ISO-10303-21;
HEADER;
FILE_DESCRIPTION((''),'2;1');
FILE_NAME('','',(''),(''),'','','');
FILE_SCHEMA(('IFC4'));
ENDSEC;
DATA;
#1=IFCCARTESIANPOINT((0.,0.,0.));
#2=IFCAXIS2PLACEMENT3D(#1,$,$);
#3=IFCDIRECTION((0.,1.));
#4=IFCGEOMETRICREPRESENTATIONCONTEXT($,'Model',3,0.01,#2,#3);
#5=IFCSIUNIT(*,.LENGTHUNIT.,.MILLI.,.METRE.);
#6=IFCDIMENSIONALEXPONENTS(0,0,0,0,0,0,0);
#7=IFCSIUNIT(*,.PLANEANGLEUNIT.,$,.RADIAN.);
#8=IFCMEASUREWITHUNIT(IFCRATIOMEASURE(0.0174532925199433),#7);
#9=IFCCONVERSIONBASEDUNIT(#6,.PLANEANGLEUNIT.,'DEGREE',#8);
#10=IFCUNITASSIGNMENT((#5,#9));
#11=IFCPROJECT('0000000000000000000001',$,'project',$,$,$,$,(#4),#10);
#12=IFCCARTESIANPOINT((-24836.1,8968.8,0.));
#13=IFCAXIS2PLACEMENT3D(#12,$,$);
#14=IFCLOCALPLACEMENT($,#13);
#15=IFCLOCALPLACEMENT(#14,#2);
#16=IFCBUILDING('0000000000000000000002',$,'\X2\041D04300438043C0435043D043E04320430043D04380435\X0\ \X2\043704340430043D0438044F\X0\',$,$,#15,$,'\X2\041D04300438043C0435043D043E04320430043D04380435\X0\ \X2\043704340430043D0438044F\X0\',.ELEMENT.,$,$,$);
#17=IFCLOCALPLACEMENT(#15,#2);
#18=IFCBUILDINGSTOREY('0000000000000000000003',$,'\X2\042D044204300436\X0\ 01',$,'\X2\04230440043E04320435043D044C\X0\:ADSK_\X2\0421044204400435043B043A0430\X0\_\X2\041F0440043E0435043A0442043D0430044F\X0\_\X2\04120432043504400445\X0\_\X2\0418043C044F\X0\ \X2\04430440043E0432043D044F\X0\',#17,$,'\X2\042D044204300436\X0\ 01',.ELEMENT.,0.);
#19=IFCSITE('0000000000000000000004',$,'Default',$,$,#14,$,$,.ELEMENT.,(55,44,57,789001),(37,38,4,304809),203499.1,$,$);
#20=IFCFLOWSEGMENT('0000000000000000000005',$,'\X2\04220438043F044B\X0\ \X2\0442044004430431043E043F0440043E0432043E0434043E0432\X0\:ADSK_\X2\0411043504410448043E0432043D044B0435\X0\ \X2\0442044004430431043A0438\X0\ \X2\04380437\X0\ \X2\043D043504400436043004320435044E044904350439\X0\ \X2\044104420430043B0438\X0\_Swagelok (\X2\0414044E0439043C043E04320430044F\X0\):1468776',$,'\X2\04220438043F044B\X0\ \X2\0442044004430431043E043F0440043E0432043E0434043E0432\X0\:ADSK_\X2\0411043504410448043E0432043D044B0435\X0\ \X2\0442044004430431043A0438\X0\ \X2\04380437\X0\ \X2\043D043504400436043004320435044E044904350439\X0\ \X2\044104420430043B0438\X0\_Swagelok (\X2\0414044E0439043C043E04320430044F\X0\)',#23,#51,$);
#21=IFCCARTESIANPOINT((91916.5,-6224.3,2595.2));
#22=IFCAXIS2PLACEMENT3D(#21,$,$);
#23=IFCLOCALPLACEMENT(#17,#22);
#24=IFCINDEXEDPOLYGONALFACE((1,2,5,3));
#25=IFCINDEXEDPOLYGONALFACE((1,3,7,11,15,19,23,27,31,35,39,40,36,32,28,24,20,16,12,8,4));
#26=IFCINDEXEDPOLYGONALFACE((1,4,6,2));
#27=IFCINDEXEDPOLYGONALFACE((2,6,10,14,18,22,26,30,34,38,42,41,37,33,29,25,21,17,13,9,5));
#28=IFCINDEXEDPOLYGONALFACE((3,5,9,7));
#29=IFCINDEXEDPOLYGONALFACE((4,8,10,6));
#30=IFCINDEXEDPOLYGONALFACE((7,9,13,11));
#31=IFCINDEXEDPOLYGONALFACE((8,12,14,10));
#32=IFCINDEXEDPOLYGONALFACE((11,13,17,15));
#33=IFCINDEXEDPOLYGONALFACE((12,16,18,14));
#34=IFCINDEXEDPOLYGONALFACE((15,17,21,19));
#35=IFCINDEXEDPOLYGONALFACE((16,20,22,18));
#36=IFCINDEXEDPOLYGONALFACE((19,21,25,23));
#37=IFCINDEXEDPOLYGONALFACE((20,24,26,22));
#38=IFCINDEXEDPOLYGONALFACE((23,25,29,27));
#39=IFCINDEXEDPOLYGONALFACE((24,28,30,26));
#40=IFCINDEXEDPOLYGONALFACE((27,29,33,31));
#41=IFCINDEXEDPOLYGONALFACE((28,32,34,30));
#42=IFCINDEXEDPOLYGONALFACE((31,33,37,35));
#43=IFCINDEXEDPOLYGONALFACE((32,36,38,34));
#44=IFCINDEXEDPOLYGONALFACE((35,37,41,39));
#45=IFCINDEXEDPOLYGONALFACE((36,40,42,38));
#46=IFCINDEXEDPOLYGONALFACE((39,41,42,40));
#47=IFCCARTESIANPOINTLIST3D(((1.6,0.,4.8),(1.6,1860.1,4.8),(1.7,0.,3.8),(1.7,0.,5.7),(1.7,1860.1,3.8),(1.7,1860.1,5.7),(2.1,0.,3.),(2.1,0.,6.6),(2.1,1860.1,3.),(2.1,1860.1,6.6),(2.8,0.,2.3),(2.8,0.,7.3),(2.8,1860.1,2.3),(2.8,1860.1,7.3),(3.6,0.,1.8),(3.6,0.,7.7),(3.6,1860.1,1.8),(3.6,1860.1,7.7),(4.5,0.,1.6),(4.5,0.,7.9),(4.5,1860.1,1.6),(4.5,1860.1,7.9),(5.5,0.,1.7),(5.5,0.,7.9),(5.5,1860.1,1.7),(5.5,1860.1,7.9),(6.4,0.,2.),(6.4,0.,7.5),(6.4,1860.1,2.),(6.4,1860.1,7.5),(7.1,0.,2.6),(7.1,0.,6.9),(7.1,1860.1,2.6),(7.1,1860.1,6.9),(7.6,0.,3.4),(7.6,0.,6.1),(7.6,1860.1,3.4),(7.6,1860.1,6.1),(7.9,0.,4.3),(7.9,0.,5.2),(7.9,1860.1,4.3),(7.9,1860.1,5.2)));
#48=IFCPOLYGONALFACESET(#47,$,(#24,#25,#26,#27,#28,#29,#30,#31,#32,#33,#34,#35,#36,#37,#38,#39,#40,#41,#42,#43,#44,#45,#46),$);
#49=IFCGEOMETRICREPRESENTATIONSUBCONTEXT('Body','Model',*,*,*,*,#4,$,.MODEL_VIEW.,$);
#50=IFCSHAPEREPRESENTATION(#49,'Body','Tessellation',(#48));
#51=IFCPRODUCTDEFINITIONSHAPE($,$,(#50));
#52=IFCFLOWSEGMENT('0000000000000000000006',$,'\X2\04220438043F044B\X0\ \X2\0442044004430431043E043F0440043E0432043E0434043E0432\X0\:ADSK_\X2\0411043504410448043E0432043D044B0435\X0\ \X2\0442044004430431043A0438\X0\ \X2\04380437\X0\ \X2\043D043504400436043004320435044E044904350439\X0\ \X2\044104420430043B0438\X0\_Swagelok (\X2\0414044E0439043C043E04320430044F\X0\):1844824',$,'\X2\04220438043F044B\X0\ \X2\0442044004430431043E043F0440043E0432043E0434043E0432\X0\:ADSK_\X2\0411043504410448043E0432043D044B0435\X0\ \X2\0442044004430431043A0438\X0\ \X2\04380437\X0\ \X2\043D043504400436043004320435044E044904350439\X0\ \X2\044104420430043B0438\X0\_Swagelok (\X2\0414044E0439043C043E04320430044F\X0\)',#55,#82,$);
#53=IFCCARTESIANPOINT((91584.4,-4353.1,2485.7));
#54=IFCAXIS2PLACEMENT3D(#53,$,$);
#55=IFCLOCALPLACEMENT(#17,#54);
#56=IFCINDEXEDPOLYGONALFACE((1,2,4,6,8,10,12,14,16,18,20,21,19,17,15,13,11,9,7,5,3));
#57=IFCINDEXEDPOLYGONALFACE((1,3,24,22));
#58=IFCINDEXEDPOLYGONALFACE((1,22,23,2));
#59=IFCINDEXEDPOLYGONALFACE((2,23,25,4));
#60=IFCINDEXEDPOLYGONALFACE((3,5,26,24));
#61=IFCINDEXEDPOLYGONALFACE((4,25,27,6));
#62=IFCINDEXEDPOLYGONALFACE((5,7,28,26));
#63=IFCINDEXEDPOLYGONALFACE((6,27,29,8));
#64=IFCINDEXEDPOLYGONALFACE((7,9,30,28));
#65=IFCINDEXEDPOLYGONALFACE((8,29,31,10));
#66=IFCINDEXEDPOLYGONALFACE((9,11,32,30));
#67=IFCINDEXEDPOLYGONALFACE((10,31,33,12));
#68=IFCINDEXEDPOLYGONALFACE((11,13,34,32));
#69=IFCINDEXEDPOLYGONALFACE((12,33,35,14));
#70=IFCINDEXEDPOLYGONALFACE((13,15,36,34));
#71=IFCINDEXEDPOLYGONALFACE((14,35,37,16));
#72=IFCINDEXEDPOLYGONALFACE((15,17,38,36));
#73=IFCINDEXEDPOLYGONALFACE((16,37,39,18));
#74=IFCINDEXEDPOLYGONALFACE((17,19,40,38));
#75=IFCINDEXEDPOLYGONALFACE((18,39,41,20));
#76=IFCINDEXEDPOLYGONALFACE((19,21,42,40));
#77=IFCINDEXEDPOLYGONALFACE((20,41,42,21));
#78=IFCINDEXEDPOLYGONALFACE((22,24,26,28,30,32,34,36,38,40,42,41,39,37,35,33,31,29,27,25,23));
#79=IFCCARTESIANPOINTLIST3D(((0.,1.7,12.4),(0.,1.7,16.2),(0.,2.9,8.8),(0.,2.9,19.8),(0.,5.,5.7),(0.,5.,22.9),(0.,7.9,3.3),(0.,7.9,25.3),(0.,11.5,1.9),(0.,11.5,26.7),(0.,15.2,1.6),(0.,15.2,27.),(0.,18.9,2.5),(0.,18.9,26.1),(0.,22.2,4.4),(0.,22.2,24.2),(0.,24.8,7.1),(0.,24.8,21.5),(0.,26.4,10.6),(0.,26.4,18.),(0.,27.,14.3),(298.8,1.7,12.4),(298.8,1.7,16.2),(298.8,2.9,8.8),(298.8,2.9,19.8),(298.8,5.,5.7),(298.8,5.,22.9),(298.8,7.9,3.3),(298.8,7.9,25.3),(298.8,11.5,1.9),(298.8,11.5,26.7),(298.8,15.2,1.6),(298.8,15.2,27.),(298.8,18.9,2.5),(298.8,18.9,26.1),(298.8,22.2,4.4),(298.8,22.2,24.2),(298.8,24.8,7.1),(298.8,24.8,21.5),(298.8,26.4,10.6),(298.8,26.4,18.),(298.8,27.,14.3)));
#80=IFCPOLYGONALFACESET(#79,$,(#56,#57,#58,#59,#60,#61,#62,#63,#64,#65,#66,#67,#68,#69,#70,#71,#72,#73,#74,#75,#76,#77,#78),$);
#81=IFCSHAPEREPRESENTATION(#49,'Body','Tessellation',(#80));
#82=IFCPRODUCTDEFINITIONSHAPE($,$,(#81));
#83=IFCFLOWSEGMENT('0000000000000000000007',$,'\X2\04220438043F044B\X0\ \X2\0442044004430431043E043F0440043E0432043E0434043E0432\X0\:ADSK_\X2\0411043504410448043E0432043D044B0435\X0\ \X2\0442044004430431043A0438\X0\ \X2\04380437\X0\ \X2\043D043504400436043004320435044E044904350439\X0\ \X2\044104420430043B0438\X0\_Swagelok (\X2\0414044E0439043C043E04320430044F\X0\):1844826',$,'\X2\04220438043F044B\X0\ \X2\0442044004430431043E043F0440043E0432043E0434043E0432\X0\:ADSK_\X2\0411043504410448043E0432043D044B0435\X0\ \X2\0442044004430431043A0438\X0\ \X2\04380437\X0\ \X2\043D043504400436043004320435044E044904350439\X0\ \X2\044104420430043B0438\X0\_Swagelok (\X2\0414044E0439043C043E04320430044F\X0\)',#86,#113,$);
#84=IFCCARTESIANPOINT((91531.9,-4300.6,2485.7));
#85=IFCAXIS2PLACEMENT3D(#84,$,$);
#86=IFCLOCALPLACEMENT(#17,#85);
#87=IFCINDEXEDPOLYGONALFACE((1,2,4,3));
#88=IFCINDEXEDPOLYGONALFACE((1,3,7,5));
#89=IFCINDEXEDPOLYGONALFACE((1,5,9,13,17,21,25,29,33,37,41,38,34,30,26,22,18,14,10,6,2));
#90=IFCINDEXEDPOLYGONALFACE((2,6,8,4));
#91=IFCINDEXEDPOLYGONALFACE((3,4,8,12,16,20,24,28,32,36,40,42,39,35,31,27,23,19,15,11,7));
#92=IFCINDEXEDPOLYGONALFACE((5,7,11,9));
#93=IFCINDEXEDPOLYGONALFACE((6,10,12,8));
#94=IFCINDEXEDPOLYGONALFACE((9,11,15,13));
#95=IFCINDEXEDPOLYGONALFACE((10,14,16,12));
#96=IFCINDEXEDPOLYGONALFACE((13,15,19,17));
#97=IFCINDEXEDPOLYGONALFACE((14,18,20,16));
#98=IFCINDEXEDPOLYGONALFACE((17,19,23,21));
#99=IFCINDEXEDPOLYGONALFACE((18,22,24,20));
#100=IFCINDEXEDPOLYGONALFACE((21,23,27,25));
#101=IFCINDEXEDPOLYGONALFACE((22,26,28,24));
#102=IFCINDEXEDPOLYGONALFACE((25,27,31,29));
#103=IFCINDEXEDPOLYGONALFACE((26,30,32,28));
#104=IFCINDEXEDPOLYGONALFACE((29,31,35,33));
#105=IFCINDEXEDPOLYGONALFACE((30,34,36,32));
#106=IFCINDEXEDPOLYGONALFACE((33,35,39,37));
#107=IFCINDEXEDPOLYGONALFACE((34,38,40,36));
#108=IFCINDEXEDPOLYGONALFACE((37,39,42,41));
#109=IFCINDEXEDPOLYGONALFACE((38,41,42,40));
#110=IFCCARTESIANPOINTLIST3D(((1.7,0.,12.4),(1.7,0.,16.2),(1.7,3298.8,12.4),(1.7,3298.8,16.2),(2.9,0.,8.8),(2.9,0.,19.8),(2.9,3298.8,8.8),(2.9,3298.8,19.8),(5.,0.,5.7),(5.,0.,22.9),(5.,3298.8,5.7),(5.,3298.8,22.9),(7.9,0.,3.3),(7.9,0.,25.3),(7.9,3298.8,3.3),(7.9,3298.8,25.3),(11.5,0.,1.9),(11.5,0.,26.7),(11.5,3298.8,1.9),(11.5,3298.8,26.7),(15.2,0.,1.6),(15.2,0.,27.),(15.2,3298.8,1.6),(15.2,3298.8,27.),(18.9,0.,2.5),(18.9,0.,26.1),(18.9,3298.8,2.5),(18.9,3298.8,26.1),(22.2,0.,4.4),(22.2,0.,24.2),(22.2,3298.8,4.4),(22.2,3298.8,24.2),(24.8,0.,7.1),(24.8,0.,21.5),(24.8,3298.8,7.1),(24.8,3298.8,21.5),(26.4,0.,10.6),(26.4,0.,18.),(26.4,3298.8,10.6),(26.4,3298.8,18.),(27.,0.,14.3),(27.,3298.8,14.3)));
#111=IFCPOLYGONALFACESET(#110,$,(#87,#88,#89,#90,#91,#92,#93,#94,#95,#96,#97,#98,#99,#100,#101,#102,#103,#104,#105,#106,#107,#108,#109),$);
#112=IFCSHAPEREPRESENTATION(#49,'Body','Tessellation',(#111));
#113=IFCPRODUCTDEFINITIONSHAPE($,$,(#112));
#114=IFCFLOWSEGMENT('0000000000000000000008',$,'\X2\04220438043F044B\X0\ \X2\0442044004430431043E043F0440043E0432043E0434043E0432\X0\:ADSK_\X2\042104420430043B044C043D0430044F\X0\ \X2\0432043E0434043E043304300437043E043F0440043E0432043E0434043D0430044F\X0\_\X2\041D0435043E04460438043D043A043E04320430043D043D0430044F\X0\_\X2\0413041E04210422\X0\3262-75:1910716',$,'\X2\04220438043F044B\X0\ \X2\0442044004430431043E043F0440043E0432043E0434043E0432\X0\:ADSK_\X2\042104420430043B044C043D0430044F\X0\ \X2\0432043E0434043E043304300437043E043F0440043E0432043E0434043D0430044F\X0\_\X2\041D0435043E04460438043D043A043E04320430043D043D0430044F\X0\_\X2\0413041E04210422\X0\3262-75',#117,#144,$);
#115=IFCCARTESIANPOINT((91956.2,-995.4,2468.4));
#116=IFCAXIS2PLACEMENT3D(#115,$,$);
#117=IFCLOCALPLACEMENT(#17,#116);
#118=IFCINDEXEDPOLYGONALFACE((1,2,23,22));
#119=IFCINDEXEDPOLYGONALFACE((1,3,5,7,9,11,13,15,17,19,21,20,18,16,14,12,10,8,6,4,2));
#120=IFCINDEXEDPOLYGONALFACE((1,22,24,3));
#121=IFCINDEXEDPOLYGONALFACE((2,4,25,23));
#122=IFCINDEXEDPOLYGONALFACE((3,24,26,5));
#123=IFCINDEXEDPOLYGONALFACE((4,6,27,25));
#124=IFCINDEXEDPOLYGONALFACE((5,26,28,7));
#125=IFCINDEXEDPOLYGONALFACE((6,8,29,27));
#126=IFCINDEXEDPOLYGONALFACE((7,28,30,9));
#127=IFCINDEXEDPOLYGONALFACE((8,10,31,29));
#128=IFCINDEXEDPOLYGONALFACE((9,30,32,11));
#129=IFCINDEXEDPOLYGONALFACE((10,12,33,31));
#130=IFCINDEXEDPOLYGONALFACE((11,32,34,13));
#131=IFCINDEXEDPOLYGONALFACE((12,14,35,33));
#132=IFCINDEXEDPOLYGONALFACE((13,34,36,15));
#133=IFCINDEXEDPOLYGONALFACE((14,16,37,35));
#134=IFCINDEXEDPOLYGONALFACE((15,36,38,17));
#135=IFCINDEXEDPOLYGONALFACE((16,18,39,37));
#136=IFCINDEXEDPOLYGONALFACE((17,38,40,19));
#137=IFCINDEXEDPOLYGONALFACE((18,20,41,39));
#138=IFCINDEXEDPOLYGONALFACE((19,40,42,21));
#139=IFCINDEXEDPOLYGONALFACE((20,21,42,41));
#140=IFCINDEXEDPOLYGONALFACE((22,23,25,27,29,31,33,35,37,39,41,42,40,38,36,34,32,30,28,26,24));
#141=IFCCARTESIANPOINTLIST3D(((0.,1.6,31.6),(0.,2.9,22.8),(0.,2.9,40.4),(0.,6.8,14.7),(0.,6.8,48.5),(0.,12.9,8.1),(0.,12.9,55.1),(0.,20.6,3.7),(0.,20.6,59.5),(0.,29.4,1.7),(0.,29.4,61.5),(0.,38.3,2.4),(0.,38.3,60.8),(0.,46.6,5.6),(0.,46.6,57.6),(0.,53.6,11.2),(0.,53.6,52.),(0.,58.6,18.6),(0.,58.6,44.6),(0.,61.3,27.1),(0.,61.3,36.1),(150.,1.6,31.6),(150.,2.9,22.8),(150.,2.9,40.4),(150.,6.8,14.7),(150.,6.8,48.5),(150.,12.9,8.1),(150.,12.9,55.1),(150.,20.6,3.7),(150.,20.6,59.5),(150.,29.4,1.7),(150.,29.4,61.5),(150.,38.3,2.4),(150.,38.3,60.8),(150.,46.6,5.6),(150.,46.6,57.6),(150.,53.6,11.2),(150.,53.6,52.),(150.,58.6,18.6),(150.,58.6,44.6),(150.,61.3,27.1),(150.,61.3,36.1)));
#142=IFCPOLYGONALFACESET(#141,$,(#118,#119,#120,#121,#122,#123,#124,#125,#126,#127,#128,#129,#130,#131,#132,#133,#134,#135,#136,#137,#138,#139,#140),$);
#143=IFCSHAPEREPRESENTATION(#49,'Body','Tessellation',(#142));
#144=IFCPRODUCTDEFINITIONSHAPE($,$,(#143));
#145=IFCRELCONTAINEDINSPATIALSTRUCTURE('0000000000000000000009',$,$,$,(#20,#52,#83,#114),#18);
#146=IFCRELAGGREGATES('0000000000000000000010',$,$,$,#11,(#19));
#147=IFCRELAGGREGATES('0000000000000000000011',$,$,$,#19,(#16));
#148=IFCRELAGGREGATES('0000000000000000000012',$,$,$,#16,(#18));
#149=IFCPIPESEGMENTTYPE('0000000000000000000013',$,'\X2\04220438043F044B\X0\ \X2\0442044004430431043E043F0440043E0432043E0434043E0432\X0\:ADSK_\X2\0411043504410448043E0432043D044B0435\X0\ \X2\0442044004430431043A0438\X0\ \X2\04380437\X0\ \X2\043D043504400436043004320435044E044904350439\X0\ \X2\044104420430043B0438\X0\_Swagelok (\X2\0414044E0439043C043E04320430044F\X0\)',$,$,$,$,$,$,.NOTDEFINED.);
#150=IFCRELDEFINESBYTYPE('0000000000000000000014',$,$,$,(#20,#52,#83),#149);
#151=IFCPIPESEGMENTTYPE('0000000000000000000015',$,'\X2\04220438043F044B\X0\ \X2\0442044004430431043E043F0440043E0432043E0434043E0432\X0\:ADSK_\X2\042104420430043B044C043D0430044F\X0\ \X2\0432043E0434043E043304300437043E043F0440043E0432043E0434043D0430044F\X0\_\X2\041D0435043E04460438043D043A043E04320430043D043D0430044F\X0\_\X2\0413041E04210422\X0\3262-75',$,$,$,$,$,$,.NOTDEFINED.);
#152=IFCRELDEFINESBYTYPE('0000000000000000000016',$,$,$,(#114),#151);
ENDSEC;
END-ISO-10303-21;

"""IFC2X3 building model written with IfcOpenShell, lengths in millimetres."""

from ifc_helpers import new_model, entity, si_unit, converted_unit, direction, frame, origin, origin_2d_with_axis, place, context, subcontext, project, spatial, circle, extrude, type_object, element, save


model = new_model("IFC2X3")

# Units and contexts
model_context = context("Model", 3, precision=0.01, world=origin(), true_north=direction((0.0, 1.0)))
body_context = subcontext(model_context, "Body", "Model", "MODEL_VIEW")
ifc_project = project(units=[si_unit("LENGTHUNIT", "METRE", prefix="MILLI"), converted_unit("PLANEANGLEUNIT", "DEGREE", entity("IfcRatioMeasure", 0.0174532925199433), si_unit("PLANEANGLEUNIT", "RADIAN"), dimensions=[0, 0, 0, 0, 0, 0, 0])], contexts=[model_context])

# Site, building, storey
site_placement = place(None, frame((-24836.1, 8968.8, 0.0)))
site = spatial("IfcSite", under=ifc_project, at=site_placement, Name="Default", CompositionType="ELEMENT", RefLatitude=(55, 44, 57, 789001), RefLongitude=(37, 38, 4, 304809), RefElevation=203499.1)
building_placement = place(site_placement, origin())
building = spatial("IfcBuilding", under=site, at=building_placement, Name="Наименование здания", LongName="Наименование здания", CompositionType="ELEMENT")
storey_placement = place(building_placement, origin())
storey = spatial("IfcBuildingStorey", under=building, at=storey_placement, Name="Этаж 01", ObjectType="Уровень:ADSK_Стрелка_Проектная_Вверх_Имя уровня", LongName="Этаж 01", CompositionType="ELEMENT", Elevation=0.0)

# Flow segments
pipe_segment_type_1 = type_object("IfcPipeSegmentType", Name="Типы трубопроводов:ADSK_Бесшовные трубки из нержавеющей стали_Swagelok (Дюймовая)", PredefinedType="NOTDEFINED")
flow_segment_1_placement = place(storey_placement, frame((91916.5, -6224.3, 2595.2)))
element("IfcFlowSegment", 1, at=flow_segment_1_placement, inside=storey, type_object=pipe_segment_type_1, Name="Типы трубопроводов:ADSK_Бесшовные трубки из нержавеющей стали_Swagelok (Дюймовая):1468776", ObjectType="Типы трубопроводов:ADSK_Бесшовные трубки из нержавеющей стали_Swagelok (Дюймовая)", context=body_context, shape_type="SweptSolid", body=[
    extrude(circle(Radius=3.2, at=origin_2d_with_axis()), frame((4.8, 0.0, 4.8), z_axis=(0.0, 1.0, 0.0), x_axis=(-1.0, 0.0, 0.0)), (0.0, 0.0, 1.0), 1860.1),
])
flow_segment_2_placement = place(storey_placement, frame((91584.4, -4353.1, 2485.7)))
element("IfcFlowSegment", 2, at=flow_segment_2_placement, inside=storey, type_object=pipe_segment_type_1, Name="Типы трубопроводов:ADSK_Бесшовные трубки из нержавеющей стали_Swagelok (Дюймовая):1844824", ObjectType="Типы трубопроводов:ADSK_Бесшовные трубки из нержавеющей стали_Swagelok (Дюймовая)", context=body_context, shape_type="SweptSolid", body=[
    extrude(circle(Radius=12.7, at=origin_2d_with_axis()), frame((0.0, 14.3, 14.3), z_axis=(1.0, 0.0, 0.0), x_axis=(0.0, 1.0, 0.0)), (0.0, 0.0, 1.0), 298.8),
])
flow_segment_3_placement = place(storey_placement, frame((91531.9, -4300.6, 2485.7)))
element("IfcFlowSegment", 3, at=flow_segment_3_placement, inside=storey, type_object=pipe_segment_type_1, Name="Типы трубопроводов:ADSK_Бесшовные трубки из нержавеющей стали_Swagelok (Дюймовая):1844826", ObjectType="Типы трубопроводов:ADSK_Бесшовные трубки из нержавеющей стали_Swagelok (Дюймовая)", context=body_context, shape_type="SweptSolid", body=[
    extrude(circle(Radius=12.7, at=origin_2d_with_axis()), frame((14.3, 0.0, 14.3), z_axis=(0.0, 1.0, 0.0), x_axis=(1.0, 0.0, 0.0)), (0.0, 0.0, 1.0), 3298.8),
])
pipe_segment_type_2 = type_object("IfcPipeSegmentType", Name="Типы трубопроводов:ADSK_Стальная водогазопроводная_Неоцинкованная_ГОСТ3262-75", PredefinedType="NOTDEFINED")
flow_segment_4_placement = place(storey_placement, frame((91956.2, -995.4, 2468.4)))
element("IfcFlowSegment", 4, at=flow_segment_4_placement, inside=storey, type_object=pipe_segment_type_2, Name="Типы трубопроводов:ADSK_Стальная водогазопроводная_Неоцинкованная_ГОСТ3262-75:1910716", ObjectType="Типы трубопроводов:ADSK_Стальная водогазопроводная_Неоцинкованная_ГОСТ3262-75", context=body_context, shape_type="SweptSolid", body=[
    extrude(circle(Radius=30.0, at=origin_2d_with_axis()), frame((0.0, 31.6, 31.6), z_axis=(1.0, 0.0, 0.0), x_axis=(0.0, -1.0, 0.0)), (0.0, 0.0, 1.0), 150.0),
])

save(model, "model.ifc")
